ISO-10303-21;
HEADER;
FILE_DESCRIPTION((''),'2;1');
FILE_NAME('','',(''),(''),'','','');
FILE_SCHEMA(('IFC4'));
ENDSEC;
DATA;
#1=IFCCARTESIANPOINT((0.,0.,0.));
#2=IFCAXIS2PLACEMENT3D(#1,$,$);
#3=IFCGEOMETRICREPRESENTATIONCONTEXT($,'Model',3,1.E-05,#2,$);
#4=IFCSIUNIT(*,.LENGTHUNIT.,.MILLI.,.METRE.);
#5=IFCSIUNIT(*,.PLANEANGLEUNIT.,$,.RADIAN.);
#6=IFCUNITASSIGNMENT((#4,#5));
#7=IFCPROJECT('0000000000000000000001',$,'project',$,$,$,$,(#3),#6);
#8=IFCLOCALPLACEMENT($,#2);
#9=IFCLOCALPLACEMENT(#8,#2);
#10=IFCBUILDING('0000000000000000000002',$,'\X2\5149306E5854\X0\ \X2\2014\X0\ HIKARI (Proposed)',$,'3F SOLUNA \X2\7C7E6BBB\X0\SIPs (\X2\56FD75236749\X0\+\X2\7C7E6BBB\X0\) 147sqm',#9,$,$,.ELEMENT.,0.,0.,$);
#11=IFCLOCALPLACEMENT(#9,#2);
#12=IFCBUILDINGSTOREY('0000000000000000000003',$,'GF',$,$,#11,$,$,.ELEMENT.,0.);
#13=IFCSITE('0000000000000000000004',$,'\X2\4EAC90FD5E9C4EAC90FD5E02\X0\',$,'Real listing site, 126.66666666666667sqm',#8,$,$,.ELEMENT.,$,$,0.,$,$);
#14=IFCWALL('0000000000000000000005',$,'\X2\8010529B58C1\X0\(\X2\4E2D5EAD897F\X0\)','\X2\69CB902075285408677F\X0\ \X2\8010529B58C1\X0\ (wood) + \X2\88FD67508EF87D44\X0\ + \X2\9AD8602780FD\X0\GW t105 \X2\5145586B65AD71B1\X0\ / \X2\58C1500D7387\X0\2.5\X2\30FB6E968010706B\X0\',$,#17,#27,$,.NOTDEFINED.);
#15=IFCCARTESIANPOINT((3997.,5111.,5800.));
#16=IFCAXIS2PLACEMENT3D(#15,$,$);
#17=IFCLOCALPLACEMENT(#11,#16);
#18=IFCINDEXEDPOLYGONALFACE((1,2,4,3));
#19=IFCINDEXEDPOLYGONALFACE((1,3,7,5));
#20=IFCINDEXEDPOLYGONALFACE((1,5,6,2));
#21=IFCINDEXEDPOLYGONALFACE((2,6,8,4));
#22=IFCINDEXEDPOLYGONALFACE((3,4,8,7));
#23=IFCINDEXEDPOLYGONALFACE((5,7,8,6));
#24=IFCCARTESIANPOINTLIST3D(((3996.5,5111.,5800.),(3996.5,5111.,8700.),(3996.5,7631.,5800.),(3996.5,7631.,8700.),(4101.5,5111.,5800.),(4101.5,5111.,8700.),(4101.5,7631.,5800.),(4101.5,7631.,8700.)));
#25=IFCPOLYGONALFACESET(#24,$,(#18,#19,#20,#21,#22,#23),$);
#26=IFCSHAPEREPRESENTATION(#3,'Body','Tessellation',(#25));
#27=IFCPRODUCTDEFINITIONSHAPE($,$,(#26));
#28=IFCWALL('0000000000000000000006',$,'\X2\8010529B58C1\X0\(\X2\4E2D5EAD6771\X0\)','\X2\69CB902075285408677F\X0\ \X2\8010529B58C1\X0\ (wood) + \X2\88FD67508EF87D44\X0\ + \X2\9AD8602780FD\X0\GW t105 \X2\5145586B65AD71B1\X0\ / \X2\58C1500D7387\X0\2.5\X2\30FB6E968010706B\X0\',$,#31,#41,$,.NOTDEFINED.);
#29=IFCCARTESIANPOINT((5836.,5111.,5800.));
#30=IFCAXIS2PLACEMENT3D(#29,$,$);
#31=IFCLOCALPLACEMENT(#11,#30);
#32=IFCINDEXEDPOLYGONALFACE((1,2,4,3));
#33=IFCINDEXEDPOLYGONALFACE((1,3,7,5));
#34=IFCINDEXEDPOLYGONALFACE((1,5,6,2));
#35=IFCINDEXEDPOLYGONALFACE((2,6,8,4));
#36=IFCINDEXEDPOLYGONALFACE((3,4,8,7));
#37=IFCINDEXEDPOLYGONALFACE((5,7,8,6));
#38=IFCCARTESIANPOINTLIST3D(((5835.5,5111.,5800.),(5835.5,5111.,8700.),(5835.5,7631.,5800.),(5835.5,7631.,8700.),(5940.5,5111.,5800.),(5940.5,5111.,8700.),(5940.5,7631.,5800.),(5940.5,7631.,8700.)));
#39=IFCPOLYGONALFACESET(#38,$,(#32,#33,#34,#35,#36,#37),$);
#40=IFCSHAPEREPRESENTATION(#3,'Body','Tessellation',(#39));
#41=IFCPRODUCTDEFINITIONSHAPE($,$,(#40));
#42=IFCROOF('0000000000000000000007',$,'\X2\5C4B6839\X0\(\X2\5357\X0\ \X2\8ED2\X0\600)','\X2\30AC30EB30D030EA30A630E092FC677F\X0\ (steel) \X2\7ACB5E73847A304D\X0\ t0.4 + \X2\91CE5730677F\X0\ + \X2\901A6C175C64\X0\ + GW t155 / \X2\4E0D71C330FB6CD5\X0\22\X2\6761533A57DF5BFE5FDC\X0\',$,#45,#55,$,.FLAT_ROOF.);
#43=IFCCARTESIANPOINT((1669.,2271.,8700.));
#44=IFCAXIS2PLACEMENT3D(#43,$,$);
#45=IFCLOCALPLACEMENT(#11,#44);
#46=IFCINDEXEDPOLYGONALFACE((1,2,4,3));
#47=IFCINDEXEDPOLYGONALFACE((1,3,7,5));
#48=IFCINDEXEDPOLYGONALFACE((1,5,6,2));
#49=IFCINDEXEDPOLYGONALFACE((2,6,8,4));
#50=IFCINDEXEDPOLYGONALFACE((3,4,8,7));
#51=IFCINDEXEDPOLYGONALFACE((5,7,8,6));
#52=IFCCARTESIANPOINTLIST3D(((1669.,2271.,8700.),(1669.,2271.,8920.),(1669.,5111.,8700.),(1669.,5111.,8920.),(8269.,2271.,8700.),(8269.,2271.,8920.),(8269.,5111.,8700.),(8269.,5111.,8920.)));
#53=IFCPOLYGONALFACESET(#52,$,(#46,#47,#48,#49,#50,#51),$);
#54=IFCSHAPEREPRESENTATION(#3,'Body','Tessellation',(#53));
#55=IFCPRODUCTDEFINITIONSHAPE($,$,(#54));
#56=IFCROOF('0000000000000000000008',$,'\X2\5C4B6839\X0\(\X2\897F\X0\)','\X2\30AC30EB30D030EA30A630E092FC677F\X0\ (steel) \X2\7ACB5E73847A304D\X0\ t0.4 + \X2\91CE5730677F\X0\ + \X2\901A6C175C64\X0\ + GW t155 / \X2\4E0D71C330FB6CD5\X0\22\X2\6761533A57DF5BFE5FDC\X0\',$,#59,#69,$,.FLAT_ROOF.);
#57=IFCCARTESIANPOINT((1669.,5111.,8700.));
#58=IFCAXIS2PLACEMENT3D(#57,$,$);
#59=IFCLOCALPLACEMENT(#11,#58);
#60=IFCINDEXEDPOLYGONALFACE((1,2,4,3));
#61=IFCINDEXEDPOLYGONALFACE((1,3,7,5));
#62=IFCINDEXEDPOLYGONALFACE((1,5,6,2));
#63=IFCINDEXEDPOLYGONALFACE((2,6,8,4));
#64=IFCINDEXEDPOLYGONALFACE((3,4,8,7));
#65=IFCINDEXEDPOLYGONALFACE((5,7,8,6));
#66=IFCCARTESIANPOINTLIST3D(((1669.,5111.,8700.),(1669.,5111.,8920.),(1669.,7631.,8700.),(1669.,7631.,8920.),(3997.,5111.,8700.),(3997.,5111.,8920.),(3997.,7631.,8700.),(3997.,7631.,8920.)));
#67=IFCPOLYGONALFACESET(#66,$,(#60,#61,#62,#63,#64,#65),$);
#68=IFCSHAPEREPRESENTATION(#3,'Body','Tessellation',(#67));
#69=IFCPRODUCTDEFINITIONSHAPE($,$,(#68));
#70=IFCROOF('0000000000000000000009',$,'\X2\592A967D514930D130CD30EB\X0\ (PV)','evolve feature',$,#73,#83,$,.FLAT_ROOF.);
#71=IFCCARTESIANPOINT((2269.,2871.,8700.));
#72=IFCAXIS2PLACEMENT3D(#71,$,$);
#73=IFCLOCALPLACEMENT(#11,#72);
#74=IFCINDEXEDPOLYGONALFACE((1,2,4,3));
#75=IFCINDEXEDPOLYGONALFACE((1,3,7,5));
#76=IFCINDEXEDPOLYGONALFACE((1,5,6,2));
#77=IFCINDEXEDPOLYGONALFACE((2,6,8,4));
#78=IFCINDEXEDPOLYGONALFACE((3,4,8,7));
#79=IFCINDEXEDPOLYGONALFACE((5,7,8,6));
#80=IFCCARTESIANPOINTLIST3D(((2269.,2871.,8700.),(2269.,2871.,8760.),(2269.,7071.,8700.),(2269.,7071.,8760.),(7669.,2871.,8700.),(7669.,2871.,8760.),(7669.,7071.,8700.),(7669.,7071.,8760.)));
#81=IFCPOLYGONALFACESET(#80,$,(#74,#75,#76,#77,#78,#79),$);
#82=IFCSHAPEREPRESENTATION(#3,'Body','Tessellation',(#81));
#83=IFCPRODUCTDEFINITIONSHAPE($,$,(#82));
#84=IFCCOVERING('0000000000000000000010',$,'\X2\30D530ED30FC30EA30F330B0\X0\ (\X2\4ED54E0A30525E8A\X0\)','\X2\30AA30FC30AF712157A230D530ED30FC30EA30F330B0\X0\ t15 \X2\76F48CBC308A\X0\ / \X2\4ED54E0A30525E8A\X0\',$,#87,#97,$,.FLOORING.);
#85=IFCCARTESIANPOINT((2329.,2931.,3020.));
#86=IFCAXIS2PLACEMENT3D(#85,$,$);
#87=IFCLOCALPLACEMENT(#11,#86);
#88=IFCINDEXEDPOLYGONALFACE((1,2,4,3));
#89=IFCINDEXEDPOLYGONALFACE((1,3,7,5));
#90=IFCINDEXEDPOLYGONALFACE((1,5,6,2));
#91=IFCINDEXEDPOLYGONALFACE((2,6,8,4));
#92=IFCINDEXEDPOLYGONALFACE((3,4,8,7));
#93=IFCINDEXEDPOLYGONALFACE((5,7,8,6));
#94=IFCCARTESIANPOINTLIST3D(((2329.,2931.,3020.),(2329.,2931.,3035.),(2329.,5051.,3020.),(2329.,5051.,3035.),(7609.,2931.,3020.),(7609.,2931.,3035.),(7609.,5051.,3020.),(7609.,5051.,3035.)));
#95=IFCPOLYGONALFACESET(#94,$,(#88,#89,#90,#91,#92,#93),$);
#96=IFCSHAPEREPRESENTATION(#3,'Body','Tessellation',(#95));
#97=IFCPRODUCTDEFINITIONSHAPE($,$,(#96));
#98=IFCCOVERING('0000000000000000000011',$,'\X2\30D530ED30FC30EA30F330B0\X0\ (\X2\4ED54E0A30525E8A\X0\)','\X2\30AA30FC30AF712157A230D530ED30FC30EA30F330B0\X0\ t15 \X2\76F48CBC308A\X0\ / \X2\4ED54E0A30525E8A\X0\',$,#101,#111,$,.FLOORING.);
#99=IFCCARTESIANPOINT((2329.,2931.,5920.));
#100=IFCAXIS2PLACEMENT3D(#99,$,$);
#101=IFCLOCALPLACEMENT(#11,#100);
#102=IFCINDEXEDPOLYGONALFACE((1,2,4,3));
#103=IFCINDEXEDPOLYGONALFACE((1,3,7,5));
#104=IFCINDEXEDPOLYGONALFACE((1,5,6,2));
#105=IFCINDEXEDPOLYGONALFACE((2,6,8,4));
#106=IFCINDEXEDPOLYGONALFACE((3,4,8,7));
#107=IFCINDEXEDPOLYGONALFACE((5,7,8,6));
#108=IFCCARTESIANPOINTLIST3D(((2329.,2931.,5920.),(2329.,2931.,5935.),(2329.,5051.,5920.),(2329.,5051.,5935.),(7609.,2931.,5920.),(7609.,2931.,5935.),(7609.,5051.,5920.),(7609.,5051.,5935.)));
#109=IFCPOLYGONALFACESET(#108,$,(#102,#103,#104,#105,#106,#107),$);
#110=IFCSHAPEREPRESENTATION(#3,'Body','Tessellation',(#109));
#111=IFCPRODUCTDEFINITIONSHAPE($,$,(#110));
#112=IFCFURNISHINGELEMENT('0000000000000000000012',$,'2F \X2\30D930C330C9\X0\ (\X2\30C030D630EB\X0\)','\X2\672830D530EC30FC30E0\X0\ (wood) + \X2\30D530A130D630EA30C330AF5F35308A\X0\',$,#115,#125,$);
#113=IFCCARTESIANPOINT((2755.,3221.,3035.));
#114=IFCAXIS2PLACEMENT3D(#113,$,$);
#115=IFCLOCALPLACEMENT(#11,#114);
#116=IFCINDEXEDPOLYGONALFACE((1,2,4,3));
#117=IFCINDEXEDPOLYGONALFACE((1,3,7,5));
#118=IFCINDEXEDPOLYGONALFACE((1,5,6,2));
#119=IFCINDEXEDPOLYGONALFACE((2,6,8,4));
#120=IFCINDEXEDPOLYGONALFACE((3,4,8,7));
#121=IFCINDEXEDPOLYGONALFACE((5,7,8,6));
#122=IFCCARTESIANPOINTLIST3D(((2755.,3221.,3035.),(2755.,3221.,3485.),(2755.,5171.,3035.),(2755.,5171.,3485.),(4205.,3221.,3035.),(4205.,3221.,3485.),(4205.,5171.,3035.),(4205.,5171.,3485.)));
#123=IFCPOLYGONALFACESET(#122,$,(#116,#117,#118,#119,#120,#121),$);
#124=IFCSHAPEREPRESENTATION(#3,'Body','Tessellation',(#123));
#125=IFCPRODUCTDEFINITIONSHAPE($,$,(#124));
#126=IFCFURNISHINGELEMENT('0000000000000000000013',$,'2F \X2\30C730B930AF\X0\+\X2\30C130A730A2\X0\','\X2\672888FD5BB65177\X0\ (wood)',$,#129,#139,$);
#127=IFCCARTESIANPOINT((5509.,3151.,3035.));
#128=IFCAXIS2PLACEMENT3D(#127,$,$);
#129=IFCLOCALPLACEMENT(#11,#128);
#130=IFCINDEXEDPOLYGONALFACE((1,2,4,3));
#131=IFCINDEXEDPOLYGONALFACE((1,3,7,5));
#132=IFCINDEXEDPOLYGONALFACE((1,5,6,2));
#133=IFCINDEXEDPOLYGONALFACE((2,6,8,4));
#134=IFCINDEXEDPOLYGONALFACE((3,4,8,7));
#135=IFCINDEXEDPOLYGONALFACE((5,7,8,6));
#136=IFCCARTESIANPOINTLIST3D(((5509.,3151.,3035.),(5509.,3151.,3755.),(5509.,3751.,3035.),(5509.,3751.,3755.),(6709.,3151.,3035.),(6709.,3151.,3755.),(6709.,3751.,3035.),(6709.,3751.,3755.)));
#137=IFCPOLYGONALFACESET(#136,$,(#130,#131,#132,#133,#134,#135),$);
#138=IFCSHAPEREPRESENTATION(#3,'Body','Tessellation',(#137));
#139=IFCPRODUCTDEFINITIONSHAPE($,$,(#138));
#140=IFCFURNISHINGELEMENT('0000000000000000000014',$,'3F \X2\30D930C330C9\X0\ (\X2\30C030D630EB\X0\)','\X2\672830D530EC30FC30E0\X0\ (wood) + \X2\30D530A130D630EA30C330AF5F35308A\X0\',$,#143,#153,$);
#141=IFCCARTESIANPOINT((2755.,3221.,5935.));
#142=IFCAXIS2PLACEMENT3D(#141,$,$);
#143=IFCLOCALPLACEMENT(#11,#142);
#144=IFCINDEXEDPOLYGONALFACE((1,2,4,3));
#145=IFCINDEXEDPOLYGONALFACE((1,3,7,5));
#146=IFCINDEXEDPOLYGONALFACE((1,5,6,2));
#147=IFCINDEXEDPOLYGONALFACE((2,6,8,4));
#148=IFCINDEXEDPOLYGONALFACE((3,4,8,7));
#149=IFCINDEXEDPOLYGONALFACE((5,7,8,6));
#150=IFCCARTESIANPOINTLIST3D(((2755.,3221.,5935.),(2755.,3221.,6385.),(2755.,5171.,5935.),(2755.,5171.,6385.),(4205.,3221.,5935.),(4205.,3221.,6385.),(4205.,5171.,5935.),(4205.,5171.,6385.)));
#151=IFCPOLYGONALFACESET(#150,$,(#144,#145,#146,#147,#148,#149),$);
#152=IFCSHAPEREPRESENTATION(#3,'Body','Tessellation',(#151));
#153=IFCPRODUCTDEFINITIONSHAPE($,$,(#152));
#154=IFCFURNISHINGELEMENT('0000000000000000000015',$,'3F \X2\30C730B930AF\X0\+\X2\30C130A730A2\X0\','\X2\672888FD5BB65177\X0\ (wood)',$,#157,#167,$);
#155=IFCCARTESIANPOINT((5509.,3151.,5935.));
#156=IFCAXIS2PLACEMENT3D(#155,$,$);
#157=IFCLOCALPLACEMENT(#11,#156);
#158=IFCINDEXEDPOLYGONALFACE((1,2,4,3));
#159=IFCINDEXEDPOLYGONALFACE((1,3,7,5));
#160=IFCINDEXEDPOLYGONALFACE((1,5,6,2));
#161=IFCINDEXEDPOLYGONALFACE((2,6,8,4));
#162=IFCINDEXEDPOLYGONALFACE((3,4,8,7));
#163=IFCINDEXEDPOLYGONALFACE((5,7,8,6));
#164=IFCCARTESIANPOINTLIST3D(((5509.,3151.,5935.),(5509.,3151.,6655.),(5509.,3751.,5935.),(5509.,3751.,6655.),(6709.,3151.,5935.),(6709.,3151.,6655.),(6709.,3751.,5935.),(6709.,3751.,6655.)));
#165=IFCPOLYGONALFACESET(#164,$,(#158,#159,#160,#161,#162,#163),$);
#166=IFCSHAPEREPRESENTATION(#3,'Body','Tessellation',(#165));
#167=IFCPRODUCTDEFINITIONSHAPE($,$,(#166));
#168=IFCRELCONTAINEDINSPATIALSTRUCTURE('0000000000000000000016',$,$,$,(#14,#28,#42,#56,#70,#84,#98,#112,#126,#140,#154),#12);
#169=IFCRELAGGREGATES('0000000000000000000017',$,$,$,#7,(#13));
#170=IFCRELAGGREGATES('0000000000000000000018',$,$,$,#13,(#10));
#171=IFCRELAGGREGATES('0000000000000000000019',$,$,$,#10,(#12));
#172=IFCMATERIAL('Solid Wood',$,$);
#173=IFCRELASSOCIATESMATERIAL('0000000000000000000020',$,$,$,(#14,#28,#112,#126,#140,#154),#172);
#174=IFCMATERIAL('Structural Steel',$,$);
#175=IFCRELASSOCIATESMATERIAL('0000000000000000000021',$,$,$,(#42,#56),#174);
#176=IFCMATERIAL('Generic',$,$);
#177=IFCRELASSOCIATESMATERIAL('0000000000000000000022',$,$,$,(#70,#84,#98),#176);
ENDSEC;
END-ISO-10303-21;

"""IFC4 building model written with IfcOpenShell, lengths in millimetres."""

from ifc_helpers import new_model, si_unit, frame, frame_2d, origin, place, context, project, spatial, rectangle, extrude, material, element, save


model = new_model("IFC4")

# Units and contexts
model_context = context("Model", 3, precision=1e-05, world=origin())
ifc_project = project(units=[si_unit("LENGTHUNIT", "METRE", prefix="MILLI"), si_unit("PLANEANGLEUNIT", "RADIAN")], contexts=[model_context])

# Site, building, storey
site_placement = place(None, origin())
site = spatial("IfcSite", under=ifc_project, at=site_placement, Name="京都府京都市", ObjectType="Real listing site, 126.66666666666667sqm", CompositionType="ELEMENT", RefElevation=0.0)
building_placement = place(site_placement, origin())
building = spatial("IfcBuilding", under=site, at=building_placement, Name="光の塔 — HIKARI (Proposed)", ObjectType="3F SOLUNA 籾殻SIPs (国産杉+籾殻) 147sqm", CompositionType="ELEMENT", ElevationOfRefHeight=0.0, ElevationOfTerrain=0.0)
storey_placement = place(building_placement, origin())
storey = spatial("IfcBuildingStorey", under=building, at=storey_placement, Name="GF", CompositionType="ELEMENT", Elevation=0.0)

# Shared definitions
ifc_material_1 = material(Name="Solid Wood")

# Walls
wall_1_placement = place(storey_placement, frame((3997.0, 5111.0, 5800.0)))
element("IfcWall", 1, at=wall_1_placement, inside=storey, material=ifc_material_1, Name="耐力壁(中庭西)", Description="構造用合板 耐力壁 (wood) + 製材軸組 + 高性能GW t105 充填断熱 / 壁倍率2.5・準耐火", PredefinedType="NOTDEFINED", context=model_context, shape_type="SweptSolid", body=[
    extrude(rectangle(XDim=105.0, YDim=2520.0, at=frame_2d((52.0, 1260.0))), frame((3997.0, 5111.0, 5800.0)), (0.0, 0.0, 1.0), 2900.0),
])
wall_2_placement = place(storey_placement, frame((5836.0, 5111.0, 5800.0)))
element("IfcWall", 2, at=wall_2_placement, inside=storey, material=ifc_material_1, Name="耐力壁(中庭東)", Description="構造用合板 耐力壁 (wood) + 製材軸組 + 高性能GW t105 充填断熱 / 壁倍率2.5・準耐火", PredefinedType="NOTDEFINED", context=model_context, shape_type="SweptSolid", body=[
    extrude(rectangle(XDim=105.0, YDim=2520.0, at=frame_2d((52.0, 1260.0))), frame((5836.0, 5111.0, 5800.0)), (0.0, 0.0, 1.0), 2900.0),
])

# Roofs
ifc_material_2 = material(Name="Structural Steel")
roof_1_placement = place(storey_placement, frame((1669.0, 2271.0, 8700.0)))
element("IfcRoof", 3, at=roof_1_placement, inside=storey, material=ifc_material_2, Name="屋根(南 軒600)", Description="ガルバリウム鋼板 (steel) 立平葺き t0.4 + 野地板 + 通気層 + GW t155 / 不燃・法22条区域対応", PredefinedType="FLAT_ROOF", context=model_context, shape_type="SweptSolid", body=[
    extrude(rectangle(XDim=6600.0, YDim=2840.0, at=frame_2d((3300.0, 1420.0))), frame((1669.0, 2271.0, 8700.0)), (0.0, 0.0, 1.0), 220.0),
])
roof_2_placement = place(storey_placement, frame((1669.0, 5111.0, 8700.0)))
element("IfcRoof", 4, at=roof_2_placement, inside=storey, material=ifc_material_2, Name="屋根(西)", Description="ガルバリウム鋼板 (steel) 立平葺き t0.4 + 野地板 + 通気層 + GW t155 / 不燃・法22条区域対応", PredefinedType="FLAT_ROOF", context=model_context, shape_type="SweptSolid", body=[
    extrude(rectangle(XDim=2328.0, YDim=2520.0, at=frame_2d((1164.0, 1260.0))), frame((1669.0, 5111.0, 8700.0)), (0.0, 0.0, 1.0), 220.0),
])
ifc_material_3 = material(Name="Generic")
roof_3_placement = place(storey_placement, frame((2269.0, 2871.0, 8700.0)))
element("IfcRoof", 5, at=roof_3_placement, inside=storey, material=ifc_material_3, Name="太陽光パネル (PV)", Description="evolve feature", PredefinedType="FLAT_ROOF", context=model_context, shape_type="SweptSolid", body=[
    extrude(rectangle(XDim=5400.0, YDim=4200.0, at=frame_2d((2700.0, 2100.0))), frame((2269.0, 2871.0, 8700.0)), (0.0, 0.0, 1.0), 60.0),
])

# Coverings
covering_1_placement = place(storey_placement, frame((2329.0, 2931.0, 3020.0)))
element("IfcCovering", 6, at=covering_1_placement, inside=storey, material=ifc_material_3, Name="フローリング (仕上げ床)", Description="オーク無垢フローリング t15 直貼り / 仕上げ床", PredefinedType="FLOORING", context=model_context, shape_type="SweptSolid", body=[
    extrude(rectangle(XDim=5280.0, YDim=2120.0, at=frame_2d((2640.0, 1060.0))), frame((2329.0, 2931.0, 3020.0)), (0.0, 0.0, 1.0), 15.0),
])
covering_2_placement = place(storey_placement, frame((2329.0, 2931.0, 5920.0)))
element("IfcCovering", 7, at=covering_2_placement, inside=storey, material=ifc_material_3, Name="フローリング (仕上げ床)", Description="オーク無垢フローリング t15 直貼り / 仕上げ床", PredefinedType="FLOORING", context=model_context, shape_type="SweptSolid", body=[
    extrude(rectangle(XDim=5280.0, YDim=2120.0, at=frame_2d((2640.0, 1060.0))), frame((2329.0, 2931.0, 5920.0)), (0.0, 0.0, 1.0), 15.0),
])

# Furnishing elements
furnishing_1_placement = place(storey_placement, frame((2755.0, 3221.0, 3035.0)))
element("IfcFurnishingElement", 8, at=furnishing_1_placement, inside=storey, material=ifc_material_1, Name="2F ベッド (ダブル)", Description="木フレーム (wood) + ファブリック張り", context=model_context, shape_type="SweptSolid", body=[
    extrude(rectangle(XDim=1450.0, YDim=1950.0, at=frame_2d((725.0, 975.0))), frame((2755.0, 3221.0, 3035.0)), (0.0, 0.0, 1.0), 450.0),
])
furnishing_2_placement = place(storey_placement, frame((5509.0, 3151.0, 3035.0)))
element("IfcFurnishingElement", 9, at=furnishing_2_placement, inside=storey, material=ifc_material_1, Name="2F デスク+チェア", Description="木製家具 (wood)", context=model_context, shape_type="SweptSolid", body=[
    extrude(rectangle(XDim=1200.0, YDim=600.0, at=frame_2d((600.0, 300.0))), frame((5509.0, 3151.0, 3035.0)), (0.0, 0.0, 1.0), 720.0),
])
furnishing_3_placement = place(storey_placement, frame((2755.0, 3221.0, 5935.0)))
element("IfcFurnishingElement", 10, at=furnishing_3_placement, inside=storey, material=ifc_material_1, Name="3F ベッド (ダブル)", Description="木フレーム (wood) + ファブリック張り", context=model_context, shape_type="SweptSolid", body=[
    extrude(rectangle(XDim=1450.0, YDim=1950.0, at=frame_2d((725.0, 975.0))), frame((2755.0, 3221.0, 5935.0)), (0.0, 0.0, 1.0), 450.0),
])
furnishing_4_placement = place(storey_placement, frame((5509.0, 3151.0, 5935.0)))
element("IfcFurnishingElement", 11, at=furnishing_4_placement, inside=storey, material=ifc_material_1, Name="3F デスク+チェア", Description="木製家具 (wood)", context=model_context, shape_type="SweptSolid", body=[
    extrude(rectangle(XDim=1200.0, YDim=600.0, at=frame_2d((600.0, 300.0))), frame((5509.0, 3151.0, 5935.0)), (0.0, 0.0, 1.0), 720.0),
])

save(model, "model.ifc")
